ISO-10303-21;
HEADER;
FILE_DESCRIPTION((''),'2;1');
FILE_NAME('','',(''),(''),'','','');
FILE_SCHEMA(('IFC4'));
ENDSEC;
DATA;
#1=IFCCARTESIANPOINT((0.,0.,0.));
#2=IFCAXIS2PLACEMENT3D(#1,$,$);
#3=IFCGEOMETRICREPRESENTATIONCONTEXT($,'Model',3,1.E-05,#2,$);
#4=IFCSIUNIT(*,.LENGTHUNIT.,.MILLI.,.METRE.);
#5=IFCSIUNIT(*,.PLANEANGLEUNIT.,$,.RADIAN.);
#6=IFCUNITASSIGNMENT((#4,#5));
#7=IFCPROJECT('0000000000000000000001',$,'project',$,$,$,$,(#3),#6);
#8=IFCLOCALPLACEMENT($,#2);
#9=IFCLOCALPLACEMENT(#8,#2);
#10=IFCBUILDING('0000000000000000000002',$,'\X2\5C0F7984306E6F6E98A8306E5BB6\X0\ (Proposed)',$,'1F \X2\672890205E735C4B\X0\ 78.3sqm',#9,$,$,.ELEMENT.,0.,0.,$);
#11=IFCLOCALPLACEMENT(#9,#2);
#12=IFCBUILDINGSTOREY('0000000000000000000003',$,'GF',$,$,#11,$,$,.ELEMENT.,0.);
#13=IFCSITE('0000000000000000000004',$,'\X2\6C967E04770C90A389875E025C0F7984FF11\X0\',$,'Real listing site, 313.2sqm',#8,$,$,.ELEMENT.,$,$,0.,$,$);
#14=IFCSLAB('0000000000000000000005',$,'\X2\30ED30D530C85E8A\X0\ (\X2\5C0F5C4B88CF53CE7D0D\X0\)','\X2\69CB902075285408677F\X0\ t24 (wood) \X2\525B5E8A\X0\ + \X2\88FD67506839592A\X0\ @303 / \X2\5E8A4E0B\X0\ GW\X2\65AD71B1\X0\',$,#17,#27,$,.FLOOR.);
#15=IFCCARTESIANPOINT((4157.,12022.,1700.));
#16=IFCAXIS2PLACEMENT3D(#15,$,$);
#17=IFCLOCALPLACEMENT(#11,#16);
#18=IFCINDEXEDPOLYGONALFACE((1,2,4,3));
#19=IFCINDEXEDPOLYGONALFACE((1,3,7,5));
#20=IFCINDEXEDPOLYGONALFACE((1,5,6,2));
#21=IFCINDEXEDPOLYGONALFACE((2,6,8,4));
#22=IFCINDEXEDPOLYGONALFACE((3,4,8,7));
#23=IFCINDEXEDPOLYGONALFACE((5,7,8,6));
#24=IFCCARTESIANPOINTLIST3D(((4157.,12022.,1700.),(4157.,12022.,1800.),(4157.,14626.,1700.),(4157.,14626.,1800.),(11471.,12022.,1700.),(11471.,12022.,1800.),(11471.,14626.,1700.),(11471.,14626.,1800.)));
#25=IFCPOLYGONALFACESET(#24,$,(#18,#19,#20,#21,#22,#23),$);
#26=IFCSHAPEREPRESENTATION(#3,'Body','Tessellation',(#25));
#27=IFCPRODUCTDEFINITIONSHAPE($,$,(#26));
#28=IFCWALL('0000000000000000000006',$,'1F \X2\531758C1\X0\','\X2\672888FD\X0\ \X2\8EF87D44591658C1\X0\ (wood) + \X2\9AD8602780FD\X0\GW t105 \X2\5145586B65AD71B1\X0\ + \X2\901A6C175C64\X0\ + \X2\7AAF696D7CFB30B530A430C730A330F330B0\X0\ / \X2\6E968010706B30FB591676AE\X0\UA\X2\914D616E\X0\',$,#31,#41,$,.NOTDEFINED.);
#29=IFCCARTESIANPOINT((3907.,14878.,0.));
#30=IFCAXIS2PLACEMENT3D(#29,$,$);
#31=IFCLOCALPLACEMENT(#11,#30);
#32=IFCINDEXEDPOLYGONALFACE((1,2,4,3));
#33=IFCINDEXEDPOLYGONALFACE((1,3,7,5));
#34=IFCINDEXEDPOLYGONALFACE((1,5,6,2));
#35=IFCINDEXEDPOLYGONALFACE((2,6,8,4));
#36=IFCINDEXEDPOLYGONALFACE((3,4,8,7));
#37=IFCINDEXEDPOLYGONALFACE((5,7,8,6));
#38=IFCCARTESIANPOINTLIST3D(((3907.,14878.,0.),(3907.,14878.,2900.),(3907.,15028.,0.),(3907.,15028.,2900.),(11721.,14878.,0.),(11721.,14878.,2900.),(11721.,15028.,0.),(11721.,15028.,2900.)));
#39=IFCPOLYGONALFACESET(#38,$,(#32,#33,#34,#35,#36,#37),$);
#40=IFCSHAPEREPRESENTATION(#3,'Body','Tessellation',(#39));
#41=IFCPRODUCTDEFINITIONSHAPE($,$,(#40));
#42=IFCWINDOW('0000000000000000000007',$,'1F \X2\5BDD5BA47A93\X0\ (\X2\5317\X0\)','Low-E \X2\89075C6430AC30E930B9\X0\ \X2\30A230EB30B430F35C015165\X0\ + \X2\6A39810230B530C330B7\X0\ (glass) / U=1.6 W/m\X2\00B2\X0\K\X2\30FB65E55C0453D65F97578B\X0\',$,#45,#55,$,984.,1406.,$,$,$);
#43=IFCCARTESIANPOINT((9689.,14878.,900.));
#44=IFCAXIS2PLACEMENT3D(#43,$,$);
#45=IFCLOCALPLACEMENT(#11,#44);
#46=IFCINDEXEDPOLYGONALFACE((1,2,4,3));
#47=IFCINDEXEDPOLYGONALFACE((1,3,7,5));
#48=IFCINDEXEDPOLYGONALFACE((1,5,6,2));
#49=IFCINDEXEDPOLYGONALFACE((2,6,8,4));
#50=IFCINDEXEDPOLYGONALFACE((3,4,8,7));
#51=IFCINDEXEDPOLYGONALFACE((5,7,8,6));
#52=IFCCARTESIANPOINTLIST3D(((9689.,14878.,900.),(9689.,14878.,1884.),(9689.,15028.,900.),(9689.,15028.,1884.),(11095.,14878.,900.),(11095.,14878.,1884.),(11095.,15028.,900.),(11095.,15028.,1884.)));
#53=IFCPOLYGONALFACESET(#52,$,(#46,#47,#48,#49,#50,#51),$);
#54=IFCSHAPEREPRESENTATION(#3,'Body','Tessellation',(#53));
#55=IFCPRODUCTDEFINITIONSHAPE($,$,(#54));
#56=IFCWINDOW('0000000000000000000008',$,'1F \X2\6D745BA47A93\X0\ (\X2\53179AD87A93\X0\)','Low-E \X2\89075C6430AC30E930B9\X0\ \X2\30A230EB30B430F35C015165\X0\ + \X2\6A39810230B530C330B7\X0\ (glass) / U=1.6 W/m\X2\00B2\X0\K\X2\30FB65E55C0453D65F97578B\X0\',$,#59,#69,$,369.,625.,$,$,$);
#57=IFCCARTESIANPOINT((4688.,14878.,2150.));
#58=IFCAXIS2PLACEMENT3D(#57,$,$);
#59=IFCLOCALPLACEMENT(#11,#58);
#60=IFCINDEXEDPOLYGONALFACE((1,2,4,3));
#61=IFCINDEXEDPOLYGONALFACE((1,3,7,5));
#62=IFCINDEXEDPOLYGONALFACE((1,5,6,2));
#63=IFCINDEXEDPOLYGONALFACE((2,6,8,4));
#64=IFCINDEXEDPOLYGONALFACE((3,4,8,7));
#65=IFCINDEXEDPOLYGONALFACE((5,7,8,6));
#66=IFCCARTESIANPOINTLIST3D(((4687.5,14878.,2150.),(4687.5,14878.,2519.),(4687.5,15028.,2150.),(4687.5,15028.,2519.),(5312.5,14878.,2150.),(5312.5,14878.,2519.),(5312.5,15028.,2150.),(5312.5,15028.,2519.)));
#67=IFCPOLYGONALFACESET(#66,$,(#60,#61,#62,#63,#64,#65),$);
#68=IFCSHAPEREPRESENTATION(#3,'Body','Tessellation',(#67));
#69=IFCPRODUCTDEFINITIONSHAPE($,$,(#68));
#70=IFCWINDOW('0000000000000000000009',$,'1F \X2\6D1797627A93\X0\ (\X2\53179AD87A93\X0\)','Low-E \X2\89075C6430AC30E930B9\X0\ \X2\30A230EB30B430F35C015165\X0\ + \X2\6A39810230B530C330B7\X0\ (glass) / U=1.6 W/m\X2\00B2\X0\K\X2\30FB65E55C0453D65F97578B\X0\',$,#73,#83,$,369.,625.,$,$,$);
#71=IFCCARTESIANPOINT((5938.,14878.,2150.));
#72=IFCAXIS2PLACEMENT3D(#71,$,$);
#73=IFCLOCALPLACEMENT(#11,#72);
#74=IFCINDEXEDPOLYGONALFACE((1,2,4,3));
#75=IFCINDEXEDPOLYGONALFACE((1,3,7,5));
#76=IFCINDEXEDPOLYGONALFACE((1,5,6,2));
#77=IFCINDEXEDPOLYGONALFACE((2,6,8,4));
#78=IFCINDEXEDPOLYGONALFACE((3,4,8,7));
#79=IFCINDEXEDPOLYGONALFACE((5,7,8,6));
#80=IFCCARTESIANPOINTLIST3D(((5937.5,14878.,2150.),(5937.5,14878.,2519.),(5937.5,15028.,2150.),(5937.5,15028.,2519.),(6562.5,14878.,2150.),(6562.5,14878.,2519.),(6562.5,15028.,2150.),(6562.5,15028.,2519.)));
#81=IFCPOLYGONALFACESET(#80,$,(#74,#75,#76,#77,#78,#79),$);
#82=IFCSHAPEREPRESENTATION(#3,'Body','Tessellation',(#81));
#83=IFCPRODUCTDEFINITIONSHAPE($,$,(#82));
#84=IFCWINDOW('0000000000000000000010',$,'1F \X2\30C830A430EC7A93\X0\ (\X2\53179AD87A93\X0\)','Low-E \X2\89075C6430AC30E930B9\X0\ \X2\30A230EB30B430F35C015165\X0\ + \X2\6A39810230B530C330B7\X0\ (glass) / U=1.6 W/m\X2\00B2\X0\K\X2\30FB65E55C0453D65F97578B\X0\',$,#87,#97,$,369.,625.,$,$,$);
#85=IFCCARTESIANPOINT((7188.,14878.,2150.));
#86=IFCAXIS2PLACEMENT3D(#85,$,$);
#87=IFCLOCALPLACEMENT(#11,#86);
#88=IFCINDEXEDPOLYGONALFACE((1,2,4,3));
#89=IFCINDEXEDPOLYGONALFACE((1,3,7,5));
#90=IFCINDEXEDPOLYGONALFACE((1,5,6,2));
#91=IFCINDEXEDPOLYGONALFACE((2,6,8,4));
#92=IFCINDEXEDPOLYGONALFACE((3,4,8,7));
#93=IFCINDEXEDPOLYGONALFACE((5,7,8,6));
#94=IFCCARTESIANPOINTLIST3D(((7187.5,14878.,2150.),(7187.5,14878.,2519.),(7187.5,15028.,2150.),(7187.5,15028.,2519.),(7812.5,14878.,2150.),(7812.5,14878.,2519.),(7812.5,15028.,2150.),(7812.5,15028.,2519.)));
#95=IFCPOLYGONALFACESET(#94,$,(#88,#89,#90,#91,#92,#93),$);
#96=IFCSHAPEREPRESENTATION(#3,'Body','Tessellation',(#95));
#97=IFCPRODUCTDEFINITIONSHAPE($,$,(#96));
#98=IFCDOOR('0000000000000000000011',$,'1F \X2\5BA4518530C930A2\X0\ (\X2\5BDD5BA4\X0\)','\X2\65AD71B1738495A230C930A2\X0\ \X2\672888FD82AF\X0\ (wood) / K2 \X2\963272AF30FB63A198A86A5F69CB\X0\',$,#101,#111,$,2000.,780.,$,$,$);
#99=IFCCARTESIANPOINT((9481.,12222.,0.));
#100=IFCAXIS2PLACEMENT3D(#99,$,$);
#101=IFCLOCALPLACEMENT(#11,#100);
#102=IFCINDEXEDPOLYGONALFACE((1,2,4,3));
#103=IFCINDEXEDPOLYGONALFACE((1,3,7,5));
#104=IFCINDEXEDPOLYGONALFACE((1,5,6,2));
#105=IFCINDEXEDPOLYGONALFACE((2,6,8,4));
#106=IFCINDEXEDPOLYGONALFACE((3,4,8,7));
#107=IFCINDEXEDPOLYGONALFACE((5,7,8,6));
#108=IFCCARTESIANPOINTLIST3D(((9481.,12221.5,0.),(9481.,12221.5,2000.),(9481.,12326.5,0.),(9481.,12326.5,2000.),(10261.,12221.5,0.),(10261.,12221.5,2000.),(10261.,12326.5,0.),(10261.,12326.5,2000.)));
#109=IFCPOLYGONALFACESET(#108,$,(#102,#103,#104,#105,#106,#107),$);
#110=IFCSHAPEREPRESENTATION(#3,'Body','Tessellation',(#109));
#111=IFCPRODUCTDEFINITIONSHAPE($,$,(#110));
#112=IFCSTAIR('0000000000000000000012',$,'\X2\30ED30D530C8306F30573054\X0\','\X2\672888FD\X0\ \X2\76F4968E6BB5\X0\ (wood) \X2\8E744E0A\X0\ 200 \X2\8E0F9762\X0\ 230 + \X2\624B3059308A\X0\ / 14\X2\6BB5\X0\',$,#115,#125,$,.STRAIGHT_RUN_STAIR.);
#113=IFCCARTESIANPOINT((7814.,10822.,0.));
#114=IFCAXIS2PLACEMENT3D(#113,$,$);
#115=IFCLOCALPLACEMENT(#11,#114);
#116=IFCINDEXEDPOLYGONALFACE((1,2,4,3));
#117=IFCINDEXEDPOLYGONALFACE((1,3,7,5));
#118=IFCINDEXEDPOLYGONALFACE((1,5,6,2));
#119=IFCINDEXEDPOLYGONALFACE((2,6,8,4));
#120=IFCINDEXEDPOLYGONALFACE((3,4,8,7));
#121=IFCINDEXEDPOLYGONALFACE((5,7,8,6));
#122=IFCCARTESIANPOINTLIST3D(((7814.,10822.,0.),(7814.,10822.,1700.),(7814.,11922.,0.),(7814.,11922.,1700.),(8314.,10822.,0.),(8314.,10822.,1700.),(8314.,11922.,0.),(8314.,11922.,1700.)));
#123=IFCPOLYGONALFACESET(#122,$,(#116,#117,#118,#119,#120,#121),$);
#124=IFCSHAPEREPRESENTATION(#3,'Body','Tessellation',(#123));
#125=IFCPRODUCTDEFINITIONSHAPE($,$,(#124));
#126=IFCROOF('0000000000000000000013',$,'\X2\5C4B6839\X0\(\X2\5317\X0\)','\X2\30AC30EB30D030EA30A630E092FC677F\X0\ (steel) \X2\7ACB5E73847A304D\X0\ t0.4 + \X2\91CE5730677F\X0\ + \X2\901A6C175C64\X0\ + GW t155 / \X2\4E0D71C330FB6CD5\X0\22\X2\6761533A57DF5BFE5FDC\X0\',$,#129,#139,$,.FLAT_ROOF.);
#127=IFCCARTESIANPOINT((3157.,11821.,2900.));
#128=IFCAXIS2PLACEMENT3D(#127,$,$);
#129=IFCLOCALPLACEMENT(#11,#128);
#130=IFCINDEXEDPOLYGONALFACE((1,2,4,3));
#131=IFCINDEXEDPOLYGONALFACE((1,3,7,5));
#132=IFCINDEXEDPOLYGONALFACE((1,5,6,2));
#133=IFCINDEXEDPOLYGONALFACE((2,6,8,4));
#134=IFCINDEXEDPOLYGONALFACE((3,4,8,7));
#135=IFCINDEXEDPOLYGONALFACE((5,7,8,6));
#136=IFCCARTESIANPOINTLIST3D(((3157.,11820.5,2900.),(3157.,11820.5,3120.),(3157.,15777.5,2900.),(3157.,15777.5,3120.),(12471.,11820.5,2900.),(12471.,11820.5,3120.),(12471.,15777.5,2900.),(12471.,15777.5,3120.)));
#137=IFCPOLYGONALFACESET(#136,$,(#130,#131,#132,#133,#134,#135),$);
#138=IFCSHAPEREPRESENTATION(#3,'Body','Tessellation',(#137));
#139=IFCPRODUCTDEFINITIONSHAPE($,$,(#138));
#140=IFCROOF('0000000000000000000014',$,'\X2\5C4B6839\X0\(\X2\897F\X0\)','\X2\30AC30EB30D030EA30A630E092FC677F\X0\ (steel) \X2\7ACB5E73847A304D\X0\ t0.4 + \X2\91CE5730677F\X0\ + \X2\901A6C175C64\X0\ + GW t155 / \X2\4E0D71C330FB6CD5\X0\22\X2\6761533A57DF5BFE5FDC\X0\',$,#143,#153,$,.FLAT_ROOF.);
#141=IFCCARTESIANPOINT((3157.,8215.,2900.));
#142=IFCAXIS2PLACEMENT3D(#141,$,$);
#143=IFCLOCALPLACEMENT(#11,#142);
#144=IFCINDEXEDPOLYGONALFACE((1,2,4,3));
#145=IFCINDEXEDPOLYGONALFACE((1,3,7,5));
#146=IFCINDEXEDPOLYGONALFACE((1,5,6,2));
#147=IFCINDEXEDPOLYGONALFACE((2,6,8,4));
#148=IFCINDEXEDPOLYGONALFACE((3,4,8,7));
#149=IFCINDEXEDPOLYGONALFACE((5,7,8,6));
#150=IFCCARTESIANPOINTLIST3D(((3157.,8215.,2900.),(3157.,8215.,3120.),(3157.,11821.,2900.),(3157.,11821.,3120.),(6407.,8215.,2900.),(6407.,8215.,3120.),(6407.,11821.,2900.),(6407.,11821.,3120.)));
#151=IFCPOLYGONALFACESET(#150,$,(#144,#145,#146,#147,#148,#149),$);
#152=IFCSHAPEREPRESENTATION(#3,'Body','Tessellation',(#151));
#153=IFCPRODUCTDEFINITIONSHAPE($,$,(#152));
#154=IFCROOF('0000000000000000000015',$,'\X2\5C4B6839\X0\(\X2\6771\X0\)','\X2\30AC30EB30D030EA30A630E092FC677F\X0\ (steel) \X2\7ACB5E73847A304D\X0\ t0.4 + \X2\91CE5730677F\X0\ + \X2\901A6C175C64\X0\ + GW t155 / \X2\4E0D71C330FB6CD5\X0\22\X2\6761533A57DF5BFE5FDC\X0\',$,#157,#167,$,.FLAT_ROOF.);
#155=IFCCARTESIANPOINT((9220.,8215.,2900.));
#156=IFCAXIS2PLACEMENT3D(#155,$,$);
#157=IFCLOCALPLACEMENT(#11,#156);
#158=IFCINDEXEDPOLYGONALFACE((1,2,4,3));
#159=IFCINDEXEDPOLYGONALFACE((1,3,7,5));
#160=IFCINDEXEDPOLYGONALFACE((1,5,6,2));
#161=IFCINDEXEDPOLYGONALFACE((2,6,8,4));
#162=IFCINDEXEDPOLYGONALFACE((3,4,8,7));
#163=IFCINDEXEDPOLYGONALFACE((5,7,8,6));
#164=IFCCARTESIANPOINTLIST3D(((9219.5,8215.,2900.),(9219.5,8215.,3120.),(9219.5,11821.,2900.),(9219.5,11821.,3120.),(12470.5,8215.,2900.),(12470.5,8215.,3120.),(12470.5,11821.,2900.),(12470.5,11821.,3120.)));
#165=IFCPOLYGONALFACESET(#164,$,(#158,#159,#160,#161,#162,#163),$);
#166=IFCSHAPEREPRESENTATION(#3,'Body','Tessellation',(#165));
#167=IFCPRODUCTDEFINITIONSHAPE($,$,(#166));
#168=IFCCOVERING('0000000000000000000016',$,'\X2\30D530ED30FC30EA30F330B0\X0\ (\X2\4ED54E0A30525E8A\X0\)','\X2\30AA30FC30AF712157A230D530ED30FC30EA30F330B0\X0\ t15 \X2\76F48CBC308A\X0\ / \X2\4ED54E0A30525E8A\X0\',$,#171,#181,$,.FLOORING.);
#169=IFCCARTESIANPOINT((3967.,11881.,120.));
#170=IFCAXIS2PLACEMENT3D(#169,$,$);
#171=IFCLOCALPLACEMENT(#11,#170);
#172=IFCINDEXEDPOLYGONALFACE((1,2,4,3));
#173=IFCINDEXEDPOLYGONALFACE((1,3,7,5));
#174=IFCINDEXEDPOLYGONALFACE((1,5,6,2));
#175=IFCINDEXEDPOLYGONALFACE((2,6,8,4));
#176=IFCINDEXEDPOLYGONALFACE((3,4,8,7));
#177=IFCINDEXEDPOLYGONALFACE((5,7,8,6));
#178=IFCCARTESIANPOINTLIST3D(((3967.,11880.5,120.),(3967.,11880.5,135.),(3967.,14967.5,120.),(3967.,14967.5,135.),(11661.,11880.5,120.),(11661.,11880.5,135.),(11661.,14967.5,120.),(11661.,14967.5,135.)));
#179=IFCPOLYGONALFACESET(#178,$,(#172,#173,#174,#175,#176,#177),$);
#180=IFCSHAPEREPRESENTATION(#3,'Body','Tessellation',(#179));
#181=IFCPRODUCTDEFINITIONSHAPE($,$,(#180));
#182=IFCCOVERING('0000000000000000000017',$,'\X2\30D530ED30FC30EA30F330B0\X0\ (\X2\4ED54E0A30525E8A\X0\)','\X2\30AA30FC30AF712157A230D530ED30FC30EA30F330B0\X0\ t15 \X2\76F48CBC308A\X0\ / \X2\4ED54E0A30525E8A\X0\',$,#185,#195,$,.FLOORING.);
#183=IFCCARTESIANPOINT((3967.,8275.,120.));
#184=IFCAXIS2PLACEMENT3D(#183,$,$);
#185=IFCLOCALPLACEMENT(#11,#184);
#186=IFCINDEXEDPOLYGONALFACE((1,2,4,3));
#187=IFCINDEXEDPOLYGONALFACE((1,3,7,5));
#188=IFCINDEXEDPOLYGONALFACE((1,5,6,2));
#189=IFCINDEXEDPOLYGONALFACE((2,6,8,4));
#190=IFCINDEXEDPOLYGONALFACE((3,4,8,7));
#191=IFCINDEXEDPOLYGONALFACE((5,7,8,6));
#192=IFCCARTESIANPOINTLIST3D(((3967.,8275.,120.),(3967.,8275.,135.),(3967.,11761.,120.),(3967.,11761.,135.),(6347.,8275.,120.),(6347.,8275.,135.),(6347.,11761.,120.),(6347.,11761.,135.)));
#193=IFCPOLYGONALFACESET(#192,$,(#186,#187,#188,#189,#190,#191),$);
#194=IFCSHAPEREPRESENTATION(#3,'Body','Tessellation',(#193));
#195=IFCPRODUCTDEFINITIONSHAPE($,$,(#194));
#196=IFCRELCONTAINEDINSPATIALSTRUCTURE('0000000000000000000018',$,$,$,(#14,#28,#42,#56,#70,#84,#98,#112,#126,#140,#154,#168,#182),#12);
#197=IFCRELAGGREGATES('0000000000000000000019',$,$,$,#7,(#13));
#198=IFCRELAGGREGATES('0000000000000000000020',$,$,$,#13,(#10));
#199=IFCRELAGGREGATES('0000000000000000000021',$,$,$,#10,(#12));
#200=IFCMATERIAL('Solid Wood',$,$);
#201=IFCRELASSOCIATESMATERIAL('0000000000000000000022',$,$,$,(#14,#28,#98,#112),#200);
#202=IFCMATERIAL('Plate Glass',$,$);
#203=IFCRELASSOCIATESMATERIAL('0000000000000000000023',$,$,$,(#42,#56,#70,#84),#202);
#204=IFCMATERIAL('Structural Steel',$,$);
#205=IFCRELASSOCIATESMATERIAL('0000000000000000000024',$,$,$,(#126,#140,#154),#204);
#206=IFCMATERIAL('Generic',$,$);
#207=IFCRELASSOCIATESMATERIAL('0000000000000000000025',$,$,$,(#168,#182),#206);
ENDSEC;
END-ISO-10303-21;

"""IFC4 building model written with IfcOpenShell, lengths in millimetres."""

from ifc_helpers import new_model, si_unit, frame, frame_2d, origin, place, context, project, spatial, rectangle, extrude, material, element, fill, save


model = new_model("IFC4")

# Units and contexts
model_context = context("Model", 3, precision=1e-05, world=origin())
ifc_project = project(units=[si_unit("LENGTHUNIT", "METRE", prefix="MILLI"), si_unit("PLANEANGLEUNIT", "RADIAN")], contexts=[model_context])

# Site, building, storey
site_placement = place(None, origin())
site = spatial("IfcSite", under=ifc_project, at=site_placement, Name="沖縄県那覇市小禄１", ObjectType="Real listing site, 313.2sqm", CompositionType="ELEMENT", RefElevation=0.0)
building_placement = place(site_placement, origin())
building = spatial("IfcBuilding", under=site, at=building_placement, Name="小禄の潮風の家 (Proposed)", ObjectType="1F 木造平屋 78.3sqm", CompositionType="ELEMENT", ElevationOfRefHeight=0.0, ElevationOfTerrain=0.0)
storey_placement = place(building_placement, origin())
storey = spatial("IfcBuildingStorey", under=building, at=storey_placement, Name="GF", CompositionType="ELEMENT", Elevation=0.0)

# Slab
ifc_material_1 = material(Name="Solid Wood")
slab_1_placement = place(storey_placement, frame((4157.0, 12022.0, 1700.0)))
element("IfcSlab", 1, at=slab_1_placement, inside=storey, material=ifc_material_1, Name="ロフト床 (小屋裏収納)", Description="構造用合板 t24 (wood) 剛床 + 製材根太 @303 / 床下 GW断熱", PredefinedType="FLOOR", context=model_context, shape_type="SweptSolid", body=[
    extrude(rectangle(XDim=7314.0, YDim=2604.0, at=frame_2d((3657.0, 1302.0))), frame((4157.0, 12022.0, 1700.0)), (0.0, 0.0, 1.0), 100.0),
])

# Wall, openings, windows
wall_1_placement = place(storey_placement, frame((3907.0, 14878.0, 0.0)))
wall_1 = element("IfcWall", 2, at=wall_1_placement, inside=storey, material=ifc_material_1, Name="1F 北壁", Description="木製 軸組外壁 (wood) + 高性能GW t105 充填断熱 + 通気層 + 窯業系サイディング / 準耐火・外皮UA配慮", PredefinedType="NOTDEFINED", context=model_context, shape_type="SweptSolid", body=[
    extrude(rectangle(XDim=7814.0, YDim=150.0, at=frame_2d((3907.0, 75.0))), frame((3907.0, 14878.0, 0.0)), (0.0, 0.0, 1.0), 2900.0),
])
opening_1_placement = place(storey_placement, frame((9689.0, 14878.0, 900.0)))
opening_1 = element("IfcOpeningElement", 3, at=opening_1_placement, cuts=wall_1, PredefinedType="NOTDEFINED", context=model_context, shape_type="SweptSolid", body=[
    extrude(rectangle(XDim=1406.0, YDim=150.0, at=frame_2d((703.0, 75.0))), frame((9689.0, 14878.0, 900.0)), (0.0, 0.0, 1.0), 984.0),
])
opening_2_placement = place(storey_placement, frame((4688.0, 14878.0, 2150.0)))
opening_2 = element("IfcOpeningElement", 4, at=opening_2_placement, cuts=wall_1, PredefinedType="NOTDEFINED", context=model_context, shape_type="SweptSolid", body=[
    extrude(rectangle(XDim=625.0, YDim=150.0, at=frame_2d((312.0, 75.0))), frame((4688.0, 14878.0, 2150.0)), (0.0, 0.0, 1.0), 369.0),
])
opening_3_placement = place(storey_placement, frame((5938.0, 14878.0, 2150.0)))
opening_3 = element("IfcOpeningElement", 5, at=opening_3_placement, cuts=wall_1, PredefinedType="NOTDEFINED", context=model_context, shape_type="SweptSolid", body=[
    extrude(rectangle(XDim=625.0, YDim=150.0, at=frame_2d((312.0, 75.0))), frame((5938.0, 14878.0, 2150.0)), (0.0, 0.0, 1.0), 369.0),
])
opening_4_placement = place(storey_placement, frame((7188.0, 14878.0, 2150.0)))
opening_4 = element("IfcOpeningElement", 6, at=opening_4_placement, cuts=wall_1, PredefinedType="NOTDEFINED", context=model_context, shape_type="SweptSolid", body=[
    extrude(rectangle(XDim=625.0, YDim=150.0, at=frame_2d((312.0, 75.0))), frame((7188.0, 14878.0, 2150.0)), (0.0, 0.0, 1.0), 369.0),
])
ifc_material_2 = material(Name="Plate Glass")
window_1_placement = place(storey_placement, frame((9689.0, 14878.0, 900.0)))
window_1 = element("IfcWindow", 7, at=window_1_placement, inside=storey, material=ifc_material_2, Name="1F 寝室窓 (北)", Description="Low-E 複層ガラス アルゴン封入 + 樹脂サッシ (glass) / U=1.6 W/m²K・日射取得型", OverallHeight=984.0, OverallWidth=1406.0, context=model_context, shape_type="SweptSolid", body=[
    extrude(rectangle(XDim=1406.0, YDim=150.0, at=frame_2d((703.0, 75.0))), frame((9689.0, 14878.0, 900.0)), (0.0, 0.0, 1.0), 984.0),
])
fill(opening_1, window_1)
window_2_placement = place(storey_placement, frame((4688.0, 14878.0, 2150.0)))
window_2 = element("IfcWindow", 8, at=window_2_placement, inside=storey, material=ifc_material_2, Name="1F 浴室窓 (北高窓)", Description="Low-E 複層ガラス アルゴン封入 + 樹脂サッシ (glass) / U=1.6 W/m²K・日射取得型", OverallHeight=369.0, OverallWidth=625.0, context=model_context, shape_type="SweptSolid", body=[
    extrude(rectangle(XDim=625.0, YDim=150.0, at=frame_2d((312.0, 75.0))), frame((4688.0, 14878.0, 2150.0)), (0.0, 0.0, 1.0), 369.0),
])
fill(opening_2, window_2)
window_3_placement = place(storey_placement, frame((5938.0, 14878.0, 2150.0)))
window_3 = element("IfcWindow", 9, at=window_3_placement, inside=storey, material=ifc_material_2, Name="1F 洗面窓 (北高窓)", Description="Low-E 複層ガラス アルゴン封入 + 樹脂サッシ (glass) / U=1.6 W/m²K・日射取得型", OverallHeight=369.0, OverallWidth=625.0, context=model_context, shape_type="SweptSolid", body=[
    extrude(rectangle(XDim=625.0, YDim=150.0, at=frame_2d((312.0, 75.0))), frame((5938.0, 14878.0, 2150.0)), (0.0, 0.0, 1.0), 369.0),
])
fill(opening_3, window_3)
window_4_placement = place(storey_placement, frame((7188.0, 14878.0, 2150.0)))
window_4 = element("IfcWindow", 10, at=window_4_placement, inside=storey, material=ifc_material_2, Name="1F トイレ窓 (北高窓)", Description="Low-E 複層ガラス アルゴン封入 + 樹脂サッシ (glass) / U=1.6 W/m²K・日射取得型", OverallHeight=369.0, OverallWidth=625.0, context=model_context, shape_type="SweptSolid", body=[
    extrude(rectangle(XDim=625.0, YDim=150.0, at=frame_2d((312.0, 75.0))), frame((7188.0, 14878.0, 2150.0)), (0.0, 0.0, 1.0), 369.0),
])
fill(opening_4, window_4)

# Door
door_1_placement = place(storey_placement, frame((9481.0, 12222.0, 0.0)))
element("IfcDoor", 11, at=door_1_placement, inside=storey, material=ifc_material_1, Name="1F 室内ドア (寝室)", Description="断熱玄関ドア 木製芯 (wood) / K2 防犯・採風機構", OverallHeight=2000.0, OverallWidth=780.0, context=model_context, shape_type="SweptSolid", body=[
    extrude(rectangle(XDim=780.0, YDim=105.0, at=frame_2d((390.0, 52.0))), frame((9481.0, 12222.0, 0.0)), (0.0, 0.0, 1.0), 2000.0),
])

# Stair
stair_placement = place(storey_placement, frame((7814.0, 10822.0, 0.0)))
element("IfcStair", 12, at=stair_placement, inside=storey, material=ifc_material_1, Name="ロフトはしご", Description="木製 直階段 (wood) 蹴上 200 踏面 230 + 手すり / 14段", PredefinedType="STRAIGHT_RUN_STAIR", context=model_context, shape_type="SweptSolid", body=[
    extrude(rectangle(XDim=500.0, YDim=1100.0, at=frame_2d((250.0, 550.0))), frame((7814.0, 10822.0, 0.0)), (0.0, 0.0, 1.0), 1700.0),
])

# Roofs
ifc_material_3 = material(Name="Structural Steel")
roof_1_placement = place(storey_placement, frame((3157.0, 11821.0, 2900.0)))
element("IfcRoof", 13, at=roof_1_placement, inside=storey, material=ifc_material_3, Name="屋根(北)", Description="ガルバリウム鋼板 (steel) 立平葺き t0.4 + 野地板 + 通気層 + GW t155 / 不燃・法22条区域対応", PredefinedType="FLAT_ROOF", context=model_context, shape_type="SweptSolid", body=[
    extrude(rectangle(XDim=9314.0, YDim=3957.0, at=frame_2d((4657.0, 1978.0))), frame((3157.0, 11821.0, 2900.0)), (0.0, 0.0, 1.0), 220.0),
])
roof_2_placement = place(storey_placement, frame((3157.0, 8215.0, 2900.0)))
element("IfcRoof", 14, at=roof_2_placement, inside=storey, material=ifc_material_3, Name="屋根(西)", Description="ガルバリウム鋼板 (steel) 立平葺き t0.4 + 野地板 + 通気層 + GW t155 / 不燃・法22条区域対応", PredefinedType="FLAT_ROOF", context=model_context, shape_type="SweptSolid", body=[
    extrude(rectangle(XDim=3250.0, YDim=3606.0, at=frame_2d((1625.0, 1803.0))), frame((3157.0, 8215.0, 2900.0)), (0.0, 0.0, 1.0), 220.0),
])
roof_3_placement = place(storey_placement, frame((9220.0, 8215.0, 2900.0)))
element("IfcRoof", 15, at=roof_3_placement, inside=storey, material=ifc_material_3, Name="屋根(東)", Description="ガルバリウム鋼板 (steel) 立平葺き t0.4 + 野地板 + 通気層 + GW t155 / 不燃・法22条区域対応", PredefinedType="FLAT_ROOF", context=model_context, shape_type="SweptSolid", body=[
    extrude(rectangle(XDim=3251.0, YDim=3606.0, at=frame_2d((1625.0, 1803.0))), frame((9220.0, 8215.0, 2900.0)), (0.0, 0.0, 1.0), 220.0),
])

# Coverings
ifc_material_4 = material(Name="Generic")
covering_1_placement = place(storey_placement, frame((3967.0, 11881.0, 120.0)))
element("IfcCovering", 16, at=covering_1_placement, inside=storey, material=ifc_material_4, Name="フローリング (仕上げ床)", Description="オーク無垢フローリング t15 直貼り / 仕上げ床", PredefinedType="FLOORING", context=model_context, shape_type="SweptSolid", body=[
    extrude(rectangle(XDim=7694.0, YDim=3087.0, at=frame_2d((3847.0, 1543.0))), frame((3967.0, 11881.0, 120.0)), (0.0, 0.0, 1.0), 15.0),
])
covering_2_placement = place(storey_placement, frame((3967.0, 8275.0, 120.0)))
element("IfcCovering", 17, at=covering_2_placement, inside=storey, material=ifc_material_4, Name="フローリング (仕上げ床)", Description="オーク無垢フローリング t15 直貼り / 仕上げ床", PredefinedType="FLOORING", context=model_context, shape_type="SweptSolid", body=[
    extrude(rectangle(XDim=2380.0, YDim=3486.0, at=frame_2d((1190.0, 1743.0))), frame((3967.0, 8275.0, 120.0)), (0.0, 0.0, 1.0), 15.0),
])

save(model, "model.ifc")
